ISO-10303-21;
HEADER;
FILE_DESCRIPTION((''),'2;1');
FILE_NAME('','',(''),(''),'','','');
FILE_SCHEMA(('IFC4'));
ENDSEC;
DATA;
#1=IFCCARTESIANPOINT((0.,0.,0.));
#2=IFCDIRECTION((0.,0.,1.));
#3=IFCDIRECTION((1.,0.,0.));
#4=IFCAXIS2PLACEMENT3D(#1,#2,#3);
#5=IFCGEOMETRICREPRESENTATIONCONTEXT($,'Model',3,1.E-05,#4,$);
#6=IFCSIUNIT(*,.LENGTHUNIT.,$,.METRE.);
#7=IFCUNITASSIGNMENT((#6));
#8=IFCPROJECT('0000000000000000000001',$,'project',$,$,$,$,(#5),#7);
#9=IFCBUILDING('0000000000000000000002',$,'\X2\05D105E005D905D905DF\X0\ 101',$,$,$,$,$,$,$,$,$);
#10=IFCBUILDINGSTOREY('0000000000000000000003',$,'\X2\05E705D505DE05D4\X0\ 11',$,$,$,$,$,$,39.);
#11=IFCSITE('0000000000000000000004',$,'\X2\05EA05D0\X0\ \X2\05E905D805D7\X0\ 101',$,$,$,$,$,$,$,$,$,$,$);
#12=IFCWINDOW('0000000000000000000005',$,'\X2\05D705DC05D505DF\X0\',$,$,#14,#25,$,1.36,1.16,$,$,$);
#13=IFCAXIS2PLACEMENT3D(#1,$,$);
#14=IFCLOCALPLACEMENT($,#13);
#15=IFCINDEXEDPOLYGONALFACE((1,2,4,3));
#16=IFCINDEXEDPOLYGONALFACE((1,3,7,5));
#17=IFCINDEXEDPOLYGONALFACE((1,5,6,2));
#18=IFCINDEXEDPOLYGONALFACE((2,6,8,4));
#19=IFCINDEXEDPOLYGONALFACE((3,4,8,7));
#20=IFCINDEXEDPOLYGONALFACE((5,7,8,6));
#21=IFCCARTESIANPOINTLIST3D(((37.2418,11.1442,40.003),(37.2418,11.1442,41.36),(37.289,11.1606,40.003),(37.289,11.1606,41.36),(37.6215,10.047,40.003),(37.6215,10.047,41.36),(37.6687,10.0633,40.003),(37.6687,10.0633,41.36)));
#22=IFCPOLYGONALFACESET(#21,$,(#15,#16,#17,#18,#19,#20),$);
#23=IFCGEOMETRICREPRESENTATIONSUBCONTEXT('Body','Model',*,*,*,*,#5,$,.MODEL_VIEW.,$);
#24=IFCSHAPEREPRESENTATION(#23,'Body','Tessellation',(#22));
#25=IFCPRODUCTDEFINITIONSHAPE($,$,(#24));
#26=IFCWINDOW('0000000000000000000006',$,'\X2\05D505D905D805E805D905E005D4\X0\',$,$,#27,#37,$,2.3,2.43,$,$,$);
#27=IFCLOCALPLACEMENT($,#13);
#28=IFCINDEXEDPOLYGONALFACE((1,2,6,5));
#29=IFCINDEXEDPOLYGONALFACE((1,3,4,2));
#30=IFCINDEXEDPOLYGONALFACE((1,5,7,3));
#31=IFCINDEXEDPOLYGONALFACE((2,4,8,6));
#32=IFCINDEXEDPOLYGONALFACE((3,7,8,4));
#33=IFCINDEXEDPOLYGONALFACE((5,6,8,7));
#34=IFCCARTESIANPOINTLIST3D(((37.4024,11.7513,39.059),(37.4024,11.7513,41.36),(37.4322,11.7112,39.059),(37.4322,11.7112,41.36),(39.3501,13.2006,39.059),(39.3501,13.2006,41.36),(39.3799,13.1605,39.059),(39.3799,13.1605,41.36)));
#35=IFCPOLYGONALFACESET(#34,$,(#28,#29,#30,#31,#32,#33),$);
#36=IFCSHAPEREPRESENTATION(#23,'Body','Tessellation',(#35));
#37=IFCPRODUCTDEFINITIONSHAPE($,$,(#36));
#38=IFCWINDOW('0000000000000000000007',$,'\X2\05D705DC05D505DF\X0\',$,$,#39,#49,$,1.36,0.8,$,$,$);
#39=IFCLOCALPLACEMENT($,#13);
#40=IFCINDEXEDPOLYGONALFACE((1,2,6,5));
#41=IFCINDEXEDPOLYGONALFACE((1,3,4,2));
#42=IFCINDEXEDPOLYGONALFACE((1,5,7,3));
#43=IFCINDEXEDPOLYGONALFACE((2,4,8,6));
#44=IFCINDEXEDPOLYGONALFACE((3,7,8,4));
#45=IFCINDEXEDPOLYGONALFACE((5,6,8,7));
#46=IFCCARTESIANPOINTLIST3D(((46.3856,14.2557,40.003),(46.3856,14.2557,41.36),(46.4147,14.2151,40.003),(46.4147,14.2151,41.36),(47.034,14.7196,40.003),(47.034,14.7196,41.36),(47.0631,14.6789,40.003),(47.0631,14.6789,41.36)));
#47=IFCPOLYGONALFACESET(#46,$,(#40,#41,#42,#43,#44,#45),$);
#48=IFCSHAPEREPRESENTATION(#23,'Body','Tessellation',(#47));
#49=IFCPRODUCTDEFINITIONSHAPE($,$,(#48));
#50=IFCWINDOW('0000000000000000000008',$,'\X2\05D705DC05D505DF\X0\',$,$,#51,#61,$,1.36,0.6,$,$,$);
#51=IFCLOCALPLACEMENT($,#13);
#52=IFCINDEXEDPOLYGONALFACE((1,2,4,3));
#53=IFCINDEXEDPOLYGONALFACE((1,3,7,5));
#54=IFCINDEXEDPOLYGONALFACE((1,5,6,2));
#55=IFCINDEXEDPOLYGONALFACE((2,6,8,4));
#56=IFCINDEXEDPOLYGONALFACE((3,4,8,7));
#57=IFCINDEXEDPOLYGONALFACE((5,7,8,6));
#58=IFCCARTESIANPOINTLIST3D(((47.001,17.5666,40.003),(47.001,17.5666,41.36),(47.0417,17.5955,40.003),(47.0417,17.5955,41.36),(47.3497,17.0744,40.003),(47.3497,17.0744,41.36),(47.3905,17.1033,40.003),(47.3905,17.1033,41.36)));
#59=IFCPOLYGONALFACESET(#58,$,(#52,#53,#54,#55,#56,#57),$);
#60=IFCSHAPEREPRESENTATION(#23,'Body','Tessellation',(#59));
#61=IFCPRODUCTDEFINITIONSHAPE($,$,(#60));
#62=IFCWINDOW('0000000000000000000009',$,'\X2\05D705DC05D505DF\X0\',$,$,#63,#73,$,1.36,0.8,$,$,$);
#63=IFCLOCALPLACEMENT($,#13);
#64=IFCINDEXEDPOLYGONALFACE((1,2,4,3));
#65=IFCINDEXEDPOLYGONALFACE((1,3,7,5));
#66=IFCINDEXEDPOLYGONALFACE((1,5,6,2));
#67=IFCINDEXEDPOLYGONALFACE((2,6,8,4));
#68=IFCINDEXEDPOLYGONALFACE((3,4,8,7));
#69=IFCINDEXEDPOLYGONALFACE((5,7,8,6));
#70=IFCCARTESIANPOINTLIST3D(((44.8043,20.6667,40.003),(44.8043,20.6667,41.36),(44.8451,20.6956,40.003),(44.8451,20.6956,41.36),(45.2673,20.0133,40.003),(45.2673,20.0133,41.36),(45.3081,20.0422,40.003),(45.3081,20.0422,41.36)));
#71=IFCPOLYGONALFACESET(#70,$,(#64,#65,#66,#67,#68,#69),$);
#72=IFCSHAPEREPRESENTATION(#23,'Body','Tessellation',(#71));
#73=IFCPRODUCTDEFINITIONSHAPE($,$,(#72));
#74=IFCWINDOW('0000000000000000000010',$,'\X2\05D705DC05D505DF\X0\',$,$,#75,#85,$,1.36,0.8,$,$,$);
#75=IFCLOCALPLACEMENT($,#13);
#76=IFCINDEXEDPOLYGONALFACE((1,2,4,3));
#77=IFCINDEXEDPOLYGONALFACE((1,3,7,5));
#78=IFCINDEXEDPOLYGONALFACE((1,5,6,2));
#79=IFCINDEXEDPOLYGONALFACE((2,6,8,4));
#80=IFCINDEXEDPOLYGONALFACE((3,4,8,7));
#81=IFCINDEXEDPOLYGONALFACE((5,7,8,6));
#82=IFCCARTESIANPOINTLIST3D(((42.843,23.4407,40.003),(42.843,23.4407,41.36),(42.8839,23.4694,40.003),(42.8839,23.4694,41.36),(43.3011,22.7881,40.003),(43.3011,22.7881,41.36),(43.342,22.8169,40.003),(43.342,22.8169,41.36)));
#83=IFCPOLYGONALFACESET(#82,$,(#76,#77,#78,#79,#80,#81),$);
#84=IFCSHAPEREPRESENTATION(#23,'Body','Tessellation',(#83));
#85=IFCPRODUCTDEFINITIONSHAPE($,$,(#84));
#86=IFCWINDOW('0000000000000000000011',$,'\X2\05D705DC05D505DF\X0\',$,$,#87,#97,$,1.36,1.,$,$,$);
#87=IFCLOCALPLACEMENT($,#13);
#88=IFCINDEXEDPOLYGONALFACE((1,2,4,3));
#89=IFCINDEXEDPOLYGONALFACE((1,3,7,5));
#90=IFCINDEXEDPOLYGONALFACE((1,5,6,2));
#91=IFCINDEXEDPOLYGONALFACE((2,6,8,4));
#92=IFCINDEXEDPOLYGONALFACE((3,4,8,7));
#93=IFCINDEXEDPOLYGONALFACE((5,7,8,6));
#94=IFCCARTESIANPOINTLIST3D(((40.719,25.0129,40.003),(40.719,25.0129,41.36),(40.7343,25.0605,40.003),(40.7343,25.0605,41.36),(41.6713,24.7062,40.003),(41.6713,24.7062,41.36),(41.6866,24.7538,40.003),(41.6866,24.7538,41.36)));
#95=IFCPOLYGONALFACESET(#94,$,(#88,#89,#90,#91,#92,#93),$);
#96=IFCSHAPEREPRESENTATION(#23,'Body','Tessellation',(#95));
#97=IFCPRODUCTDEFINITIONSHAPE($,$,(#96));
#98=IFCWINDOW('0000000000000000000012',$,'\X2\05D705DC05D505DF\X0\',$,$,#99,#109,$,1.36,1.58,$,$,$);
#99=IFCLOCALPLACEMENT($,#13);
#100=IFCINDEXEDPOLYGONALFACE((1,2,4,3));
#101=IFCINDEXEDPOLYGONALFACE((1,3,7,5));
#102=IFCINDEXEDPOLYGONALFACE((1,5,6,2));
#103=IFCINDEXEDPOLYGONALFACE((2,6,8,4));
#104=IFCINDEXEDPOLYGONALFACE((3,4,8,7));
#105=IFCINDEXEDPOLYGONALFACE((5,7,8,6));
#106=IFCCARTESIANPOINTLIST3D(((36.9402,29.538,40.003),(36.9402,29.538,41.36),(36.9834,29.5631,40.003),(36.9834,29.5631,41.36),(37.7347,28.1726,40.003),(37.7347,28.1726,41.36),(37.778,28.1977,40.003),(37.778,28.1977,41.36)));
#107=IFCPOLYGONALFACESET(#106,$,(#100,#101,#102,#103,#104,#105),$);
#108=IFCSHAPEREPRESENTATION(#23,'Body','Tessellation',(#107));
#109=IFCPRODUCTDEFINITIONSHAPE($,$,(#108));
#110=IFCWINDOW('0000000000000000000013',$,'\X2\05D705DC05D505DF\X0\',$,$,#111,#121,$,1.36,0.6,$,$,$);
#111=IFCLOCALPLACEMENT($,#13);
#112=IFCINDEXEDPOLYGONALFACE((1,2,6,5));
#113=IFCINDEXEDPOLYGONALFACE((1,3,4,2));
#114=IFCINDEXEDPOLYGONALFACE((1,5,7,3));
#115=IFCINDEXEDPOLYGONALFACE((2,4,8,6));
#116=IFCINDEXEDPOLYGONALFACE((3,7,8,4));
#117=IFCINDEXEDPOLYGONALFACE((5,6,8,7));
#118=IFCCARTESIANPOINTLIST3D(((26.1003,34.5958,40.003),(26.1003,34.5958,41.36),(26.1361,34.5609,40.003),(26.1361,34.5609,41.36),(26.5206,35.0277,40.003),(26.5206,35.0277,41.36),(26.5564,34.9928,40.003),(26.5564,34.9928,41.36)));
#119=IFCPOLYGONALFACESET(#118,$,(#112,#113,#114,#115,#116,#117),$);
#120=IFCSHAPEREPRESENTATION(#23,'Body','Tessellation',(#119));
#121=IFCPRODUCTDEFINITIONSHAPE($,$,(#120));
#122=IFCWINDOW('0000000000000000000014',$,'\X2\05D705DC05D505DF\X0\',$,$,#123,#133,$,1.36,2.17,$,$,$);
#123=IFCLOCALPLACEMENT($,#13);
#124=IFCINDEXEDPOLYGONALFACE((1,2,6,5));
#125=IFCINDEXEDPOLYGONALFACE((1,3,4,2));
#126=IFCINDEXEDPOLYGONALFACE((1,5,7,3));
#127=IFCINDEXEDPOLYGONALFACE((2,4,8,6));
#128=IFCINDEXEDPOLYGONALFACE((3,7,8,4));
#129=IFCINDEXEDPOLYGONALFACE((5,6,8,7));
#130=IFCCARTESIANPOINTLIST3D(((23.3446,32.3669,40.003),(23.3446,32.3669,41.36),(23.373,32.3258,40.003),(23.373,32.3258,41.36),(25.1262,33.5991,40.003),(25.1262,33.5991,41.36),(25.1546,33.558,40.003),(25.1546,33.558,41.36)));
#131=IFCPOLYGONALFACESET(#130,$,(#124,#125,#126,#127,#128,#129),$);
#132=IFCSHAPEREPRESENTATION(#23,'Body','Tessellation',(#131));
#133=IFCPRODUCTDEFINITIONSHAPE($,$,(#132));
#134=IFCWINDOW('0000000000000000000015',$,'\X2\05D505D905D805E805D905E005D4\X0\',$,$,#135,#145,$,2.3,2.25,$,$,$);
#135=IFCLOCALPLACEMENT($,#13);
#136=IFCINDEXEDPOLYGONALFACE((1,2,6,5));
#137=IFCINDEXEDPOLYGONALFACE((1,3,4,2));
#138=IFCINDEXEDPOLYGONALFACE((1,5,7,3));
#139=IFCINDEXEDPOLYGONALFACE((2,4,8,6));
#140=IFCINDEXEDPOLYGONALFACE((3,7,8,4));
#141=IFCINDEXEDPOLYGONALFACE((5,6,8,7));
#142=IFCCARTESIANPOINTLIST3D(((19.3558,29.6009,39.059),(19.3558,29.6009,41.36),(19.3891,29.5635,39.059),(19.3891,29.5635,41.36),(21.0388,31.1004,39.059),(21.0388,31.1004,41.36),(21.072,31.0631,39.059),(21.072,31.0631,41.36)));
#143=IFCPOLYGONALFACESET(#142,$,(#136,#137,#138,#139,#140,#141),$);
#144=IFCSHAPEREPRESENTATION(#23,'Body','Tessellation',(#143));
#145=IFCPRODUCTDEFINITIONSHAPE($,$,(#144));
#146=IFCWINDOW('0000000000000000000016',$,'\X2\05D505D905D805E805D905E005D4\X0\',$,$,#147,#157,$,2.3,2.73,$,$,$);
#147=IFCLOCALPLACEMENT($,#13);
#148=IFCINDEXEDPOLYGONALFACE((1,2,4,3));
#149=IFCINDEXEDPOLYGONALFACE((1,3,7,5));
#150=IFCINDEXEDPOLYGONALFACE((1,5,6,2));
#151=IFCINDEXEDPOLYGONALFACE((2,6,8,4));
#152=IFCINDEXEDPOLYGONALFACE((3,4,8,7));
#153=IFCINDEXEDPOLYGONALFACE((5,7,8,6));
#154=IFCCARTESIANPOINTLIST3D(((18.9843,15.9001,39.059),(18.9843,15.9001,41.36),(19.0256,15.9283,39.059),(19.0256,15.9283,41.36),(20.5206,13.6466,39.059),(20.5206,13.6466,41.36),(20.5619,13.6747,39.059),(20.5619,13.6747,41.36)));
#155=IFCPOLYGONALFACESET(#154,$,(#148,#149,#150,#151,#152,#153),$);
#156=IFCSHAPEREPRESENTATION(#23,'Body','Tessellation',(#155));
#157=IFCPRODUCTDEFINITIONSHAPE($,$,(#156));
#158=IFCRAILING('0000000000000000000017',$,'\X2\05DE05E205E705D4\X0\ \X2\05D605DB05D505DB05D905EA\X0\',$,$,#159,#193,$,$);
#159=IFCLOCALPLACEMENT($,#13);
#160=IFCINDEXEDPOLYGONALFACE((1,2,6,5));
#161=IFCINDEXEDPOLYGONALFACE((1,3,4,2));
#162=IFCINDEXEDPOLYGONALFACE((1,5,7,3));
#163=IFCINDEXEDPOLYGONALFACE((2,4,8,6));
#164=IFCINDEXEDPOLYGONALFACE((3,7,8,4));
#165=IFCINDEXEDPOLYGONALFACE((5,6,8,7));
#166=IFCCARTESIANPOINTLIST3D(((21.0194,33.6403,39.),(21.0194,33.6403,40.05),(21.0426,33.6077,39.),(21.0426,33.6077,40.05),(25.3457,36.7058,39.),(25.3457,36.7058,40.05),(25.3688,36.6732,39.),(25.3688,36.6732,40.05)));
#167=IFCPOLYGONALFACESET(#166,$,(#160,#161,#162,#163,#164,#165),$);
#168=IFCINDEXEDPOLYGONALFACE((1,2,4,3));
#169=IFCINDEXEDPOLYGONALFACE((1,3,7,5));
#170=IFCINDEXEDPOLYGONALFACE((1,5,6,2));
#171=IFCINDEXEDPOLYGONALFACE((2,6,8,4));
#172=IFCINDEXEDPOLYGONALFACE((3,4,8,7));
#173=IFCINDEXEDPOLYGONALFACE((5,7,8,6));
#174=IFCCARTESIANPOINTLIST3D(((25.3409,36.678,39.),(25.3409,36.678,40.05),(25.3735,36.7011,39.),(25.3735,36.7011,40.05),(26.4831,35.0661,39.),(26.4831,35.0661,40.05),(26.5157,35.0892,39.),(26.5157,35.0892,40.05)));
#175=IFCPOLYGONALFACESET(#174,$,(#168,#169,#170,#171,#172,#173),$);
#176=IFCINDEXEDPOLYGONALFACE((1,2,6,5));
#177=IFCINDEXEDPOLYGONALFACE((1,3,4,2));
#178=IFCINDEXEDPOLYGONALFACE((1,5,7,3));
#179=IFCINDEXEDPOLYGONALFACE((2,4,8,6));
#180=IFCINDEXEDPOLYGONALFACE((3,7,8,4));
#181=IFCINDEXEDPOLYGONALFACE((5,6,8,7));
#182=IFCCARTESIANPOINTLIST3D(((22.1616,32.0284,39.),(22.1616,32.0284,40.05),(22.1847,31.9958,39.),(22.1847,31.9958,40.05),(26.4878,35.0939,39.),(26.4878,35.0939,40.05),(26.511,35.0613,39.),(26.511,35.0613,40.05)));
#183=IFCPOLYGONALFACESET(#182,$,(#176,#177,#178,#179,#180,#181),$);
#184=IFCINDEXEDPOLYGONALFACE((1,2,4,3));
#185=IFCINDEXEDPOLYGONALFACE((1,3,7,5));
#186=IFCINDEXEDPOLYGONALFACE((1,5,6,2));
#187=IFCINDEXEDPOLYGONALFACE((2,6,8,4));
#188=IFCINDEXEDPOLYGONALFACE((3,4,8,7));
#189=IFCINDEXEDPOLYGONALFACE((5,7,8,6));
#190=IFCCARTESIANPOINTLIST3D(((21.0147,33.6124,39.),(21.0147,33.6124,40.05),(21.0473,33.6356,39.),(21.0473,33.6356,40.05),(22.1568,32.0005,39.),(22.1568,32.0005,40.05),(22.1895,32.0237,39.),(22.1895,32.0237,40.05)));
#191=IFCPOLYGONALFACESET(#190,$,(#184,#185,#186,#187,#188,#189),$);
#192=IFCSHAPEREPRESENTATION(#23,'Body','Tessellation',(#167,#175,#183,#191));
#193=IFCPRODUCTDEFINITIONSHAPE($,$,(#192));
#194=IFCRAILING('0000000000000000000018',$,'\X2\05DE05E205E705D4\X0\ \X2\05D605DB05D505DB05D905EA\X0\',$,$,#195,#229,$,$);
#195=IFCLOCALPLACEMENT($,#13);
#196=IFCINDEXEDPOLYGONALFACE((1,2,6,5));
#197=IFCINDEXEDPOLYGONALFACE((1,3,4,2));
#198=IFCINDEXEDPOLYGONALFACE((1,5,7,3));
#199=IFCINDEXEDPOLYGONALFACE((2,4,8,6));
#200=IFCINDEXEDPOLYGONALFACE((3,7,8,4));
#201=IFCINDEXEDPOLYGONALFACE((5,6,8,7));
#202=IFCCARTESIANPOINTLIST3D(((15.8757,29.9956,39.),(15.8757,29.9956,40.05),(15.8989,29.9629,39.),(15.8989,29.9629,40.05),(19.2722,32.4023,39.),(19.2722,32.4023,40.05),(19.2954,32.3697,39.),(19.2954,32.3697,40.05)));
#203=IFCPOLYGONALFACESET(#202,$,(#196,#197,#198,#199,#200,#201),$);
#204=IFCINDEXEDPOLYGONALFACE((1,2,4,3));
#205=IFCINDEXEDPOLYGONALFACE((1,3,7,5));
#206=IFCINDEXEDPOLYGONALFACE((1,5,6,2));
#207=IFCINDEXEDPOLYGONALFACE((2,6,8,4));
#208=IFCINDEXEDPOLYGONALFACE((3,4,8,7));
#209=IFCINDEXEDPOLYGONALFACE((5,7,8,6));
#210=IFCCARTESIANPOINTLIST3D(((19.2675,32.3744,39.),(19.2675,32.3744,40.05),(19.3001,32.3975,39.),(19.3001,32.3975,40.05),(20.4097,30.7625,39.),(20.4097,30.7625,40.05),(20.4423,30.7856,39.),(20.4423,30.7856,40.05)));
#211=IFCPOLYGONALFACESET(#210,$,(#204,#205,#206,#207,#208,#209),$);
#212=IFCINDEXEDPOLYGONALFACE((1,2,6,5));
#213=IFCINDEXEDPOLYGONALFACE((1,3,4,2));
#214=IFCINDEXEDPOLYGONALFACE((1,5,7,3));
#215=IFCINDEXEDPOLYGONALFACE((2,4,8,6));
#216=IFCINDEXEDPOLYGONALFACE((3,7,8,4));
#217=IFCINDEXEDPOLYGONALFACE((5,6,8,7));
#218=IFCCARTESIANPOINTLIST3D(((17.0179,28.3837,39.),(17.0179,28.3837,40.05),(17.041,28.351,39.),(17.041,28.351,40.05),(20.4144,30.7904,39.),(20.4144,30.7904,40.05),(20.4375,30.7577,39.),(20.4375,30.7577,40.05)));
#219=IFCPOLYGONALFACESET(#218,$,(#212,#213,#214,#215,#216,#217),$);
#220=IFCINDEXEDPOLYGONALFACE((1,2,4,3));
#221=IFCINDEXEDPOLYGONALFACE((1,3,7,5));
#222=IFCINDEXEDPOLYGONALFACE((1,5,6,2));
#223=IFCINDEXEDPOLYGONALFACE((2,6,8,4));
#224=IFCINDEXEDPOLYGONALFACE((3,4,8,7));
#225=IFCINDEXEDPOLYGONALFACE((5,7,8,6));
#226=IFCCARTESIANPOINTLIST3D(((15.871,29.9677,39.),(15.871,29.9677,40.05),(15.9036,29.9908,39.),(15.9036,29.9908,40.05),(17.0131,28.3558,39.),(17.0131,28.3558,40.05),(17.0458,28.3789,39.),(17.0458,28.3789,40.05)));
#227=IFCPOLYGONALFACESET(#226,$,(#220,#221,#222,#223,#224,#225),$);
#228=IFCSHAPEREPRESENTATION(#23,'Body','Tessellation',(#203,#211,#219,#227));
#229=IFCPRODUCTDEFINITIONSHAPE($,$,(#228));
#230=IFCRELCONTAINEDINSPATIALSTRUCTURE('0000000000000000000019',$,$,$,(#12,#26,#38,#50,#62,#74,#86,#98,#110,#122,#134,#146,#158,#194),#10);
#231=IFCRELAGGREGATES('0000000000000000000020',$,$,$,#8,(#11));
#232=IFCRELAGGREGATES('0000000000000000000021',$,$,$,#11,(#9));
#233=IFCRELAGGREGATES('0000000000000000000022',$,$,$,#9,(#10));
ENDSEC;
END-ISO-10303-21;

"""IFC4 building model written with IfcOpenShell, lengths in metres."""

from ifc_helpers import new_model, si_unit, frame, origin_with_axes, context, subcontext, project, spatial, polyline, outline, extrude, element, save


model = new_model("IFC4")

# Units and contexts
model_context = context("Model", 3, precision=1e-05, world=origin_with_axes())
body_context = subcontext(model_context, "Body", "Model", "MODEL_VIEW")
ifc_project = project(units=[si_unit("LENGTHUNIT", "METRE")], contexts=[model_context])

# Site, building, storey
site = spatial("IfcSite", under=ifc_project, Name="תא שטח 101")
building = spatial("IfcBuilding", under=site, Name="בניין 101")
storey = spatial("IfcBuildingStorey", under=building, Name="קומה 11", Elevation=39.0)

# Windows
element("IfcWindow", 1, inside=storey, Name="חלון", OverallHeight=1.36, OverallWidth=1.16, context=body_context, shape_type="SweptSolid", body=[
    extrude(outline(polyline([(37.6687, 10.0633), (37.289, 11.1606), (37.2418, 11.1442), (37.6215, 10.047), (37.6687, 10.0633)])), frame((0.0, 0.0, 40.003)), (0.0, 0.0, 1.0), 1.357),
])
element("IfcWindow", 2, inside=storey, Name="ויטרינה", OverallHeight=2.3, OverallWidth=2.43, context=body_context, shape_type="SweptSolid", body=[
    extrude(outline(polyline([(37.4322, 11.7112), (39.3799, 13.1605), (39.3501, 13.2006), (37.4024, 11.7513), (37.4322, 11.7112)])), frame((0.0, 0.0, 39.059)), (0.0, 0.0, 1.0), 2.301),
])
element("IfcWindow", 3, inside=storey, Name="חלון", OverallHeight=1.36, OverallWidth=0.8, context=body_context, shape_type="SweptSolid", body=[
    extrude(outline(polyline([(46.4147, 14.2151), (47.0631, 14.6789), (47.034, 14.7196), (46.3856, 14.2557), (46.4147, 14.2151)])), frame((0.0, 0.0, 40.003)), (0.0, 0.0, 1.0), 1.357),
])
element("IfcWindow", 4, inside=storey, Name="חלון", OverallHeight=1.36, OverallWidth=0.6, context=body_context, shape_type="SweptSolid", body=[
    extrude(outline(polyline([(47.3905, 17.1033), (47.0417, 17.5955), (47.001, 17.5666), (47.3497, 17.0744), (47.3905, 17.1033)])), frame((0.0, 0.0, 40.003)), (0.0, 0.0, 1.0), 1.357),
])
element("IfcWindow", 5, inside=storey, Name="חלון", OverallHeight=1.36, OverallWidth=0.8, context=body_context, shape_type="SweptSolid", body=[
    extrude(outline(polyline([(45.3081, 20.0422), (44.8451, 20.6956), (44.8043, 20.6667), (45.2673, 20.0133), (45.3081, 20.0422)])), frame((0.0, 0.0, 40.003)), (0.0, 0.0, 1.0), 1.357),
])
element("IfcWindow", 6, inside=storey, Name="חלון", OverallHeight=1.36, OverallWidth=0.8, context=body_context, shape_type="SweptSolid", body=[
    extrude(outline(polyline([(43.342, 22.8169), (42.8839, 23.4694), (42.843, 23.4407), (43.3011, 22.7881), (43.342, 22.8169)])), frame((0.0, 0.0, 40.003)), (0.0, 0.0, 1.0), 1.357),
])
element("IfcWindow", 7, inside=storey, Name="חלון", OverallHeight=1.36, OverallWidth=1.0, context=body_context, shape_type="SweptSolid", body=[
    extrude(outline(polyline([(41.6866, 24.7538), (40.7343, 25.0605), (40.719, 25.0129), (41.6713, 24.7062), (41.6866, 24.7538)])), frame((0.0, 0.0, 40.003)), (0.0, 0.0, 1.0), 1.357),
])
element("IfcWindow", 8, inside=storey, Name="חלון", OverallHeight=1.36, OverallWidth=1.58, context=body_context, shape_type="SweptSolid", body=[
    extrude(outline(polyline([(37.778, 28.1977), (36.9834, 29.5631), (36.9402, 29.538), (37.7347, 28.1726), (37.778, 28.1977)])), frame((0.0, 0.0, 40.003)), (0.0, 0.0, 1.0), 1.357),
])
element("IfcWindow", 9, inside=storey, Name="חלון", OverallHeight=1.36, OverallWidth=0.6, context=body_context, shape_type="SweptSolid", body=[
    extrude(outline(polyline([(26.5206, 35.0277), (26.1003, 34.5958), (26.1361, 34.5609), (26.5564, 34.9928), (26.5206, 35.0277)])), frame((0.0, 0.0, 40.003)), (0.0, 0.0, 1.0), 1.357),
])
element("IfcWindow", 10, inside=storey, Name="חלון", OverallHeight=1.36, OverallWidth=2.17, context=body_context, shape_type="SweptSolid", body=[
    extrude(outline(polyline([(25.1262, 33.5991), (23.3446, 32.3669), (23.373, 32.3258), (25.1546, 33.558), (25.1262, 33.5991)])), frame((0.0, 0.0, 40.003)), (0.0, 0.0, 1.0), 1.357),
])
element("IfcWindow", 11, inside=storey, Name="ויטרינה", OverallHeight=2.3, OverallWidth=2.25, context=body_context, shape_type="SweptSolid", body=[
    extrude(outline(polyline([(21.0388, 31.1004), (19.3558, 29.6009), (19.3891, 29.5635), (21.072, 31.0631), (21.0388, 31.1004)])), frame((0.0, 0.0, 39.059)), (0.0, 0.0, 1.0), 2.301),
])
element("IfcWindow", 12, inside=storey, Name="ויטרינה", OverallHeight=2.3, OverallWidth=2.73, context=body_context, shape_type="SweptSolid", body=[
    extrude(outline(polyline([(18.9843, 15.9001), (20.5206, 13.6466), (20.5619, 13.6747), (19.0256, 15.9283), (18.9843, 15.9001)])), frame((0.0, 0.0, 39.059)), (0.0, 0.0, 1.0), 2.301),
])

# Railings
element("IfcRailing", 13, inside=storey, Name="מעקה זכוכית", context=body_context, shape_type="SweptSolid", body=[
    extrude(outline(polyline([(21.0426, 33.6077), (25.3688, 36.6732), (25.3457, 36.7058), (21.0194, 33.6403), (21.0426, 33.6077)])), frame((0.0, 0.0, 39.0)), (0.0, 0.0, 1.0), 1.05),
    extrude(outline(polyline([(25.3409, 36.678), (26.4831, 35.0661), (26.5157, 35.0892), (25.3735, 36.7011), (25.3409, 36.678)])), frame((0.0, 0.0, 39.0)), (0.0, 0.0, 1.0), 1.05),
    extrude(outline(polyline([(26.4878, 35.0939), (22.1616, 32.0284), (22.1847, 31.9958), (26.511, 35.0613), (26.4878, 35.0939)])), frame((0.0, 0.0, 39.0)), (0.0, 0.0, 1.0), 1.05),
    extrude(outline(polyline([(22.1895, 32.0237), (21.0473, 33.6356), (21.0147, 33.6124), (22.1568, 32.0005), (22.1895, 32.0237)])), frame((0.0, 0.0, 39.0)), (0.0, 0.0, 1.0), 1.05),
])
element("IfcRailing", 14, inside=storey, Name="מעקה זכוכית", context=body_context, shape_type="SweptSolid", body=[
    extrude(outline(polyline([(15.8989, 29.9629), (19.2954, 32.3697), (19.2722, 32.4023), (15.8757, 29.9956), (15.8989, 29.9629)])), frame((0.0, 0.0, 39.0)), (0.0, 0.0, 1.0), 1.05),
    extrude(outline(polyline([(19.2675, 32.3744), (20.4097, 30.7625), (20.4423, 30.7856), (19.3001, 32.3975), (19.2675, 32.3744)])), frame((0.0, 0.0, 39.0)), (0.0, 0.0, 1.0), 1.05),
    extrude(outline(polyline([(20.4144, 30.7904), (17.0179, 28.3837), (17.041, 28.351), (20.4375, 30.7577), (20.4144, 30.7904)])), frame((0.0, 0.0, 39.0)), (0.0, 0.0, 1.0), 1.05),
    extrude(outline(polyline([(17.0458, 28.3789), (15.9036, 29.9908), (15.871, 29.9677), (17.0131, 28.3558), (17.0458, 28.3789)])), frame((0.0, 0.0, 39.0)), (0.0, 0.0, 1.0), 1.05),
])

save(model, "model.ifc")
